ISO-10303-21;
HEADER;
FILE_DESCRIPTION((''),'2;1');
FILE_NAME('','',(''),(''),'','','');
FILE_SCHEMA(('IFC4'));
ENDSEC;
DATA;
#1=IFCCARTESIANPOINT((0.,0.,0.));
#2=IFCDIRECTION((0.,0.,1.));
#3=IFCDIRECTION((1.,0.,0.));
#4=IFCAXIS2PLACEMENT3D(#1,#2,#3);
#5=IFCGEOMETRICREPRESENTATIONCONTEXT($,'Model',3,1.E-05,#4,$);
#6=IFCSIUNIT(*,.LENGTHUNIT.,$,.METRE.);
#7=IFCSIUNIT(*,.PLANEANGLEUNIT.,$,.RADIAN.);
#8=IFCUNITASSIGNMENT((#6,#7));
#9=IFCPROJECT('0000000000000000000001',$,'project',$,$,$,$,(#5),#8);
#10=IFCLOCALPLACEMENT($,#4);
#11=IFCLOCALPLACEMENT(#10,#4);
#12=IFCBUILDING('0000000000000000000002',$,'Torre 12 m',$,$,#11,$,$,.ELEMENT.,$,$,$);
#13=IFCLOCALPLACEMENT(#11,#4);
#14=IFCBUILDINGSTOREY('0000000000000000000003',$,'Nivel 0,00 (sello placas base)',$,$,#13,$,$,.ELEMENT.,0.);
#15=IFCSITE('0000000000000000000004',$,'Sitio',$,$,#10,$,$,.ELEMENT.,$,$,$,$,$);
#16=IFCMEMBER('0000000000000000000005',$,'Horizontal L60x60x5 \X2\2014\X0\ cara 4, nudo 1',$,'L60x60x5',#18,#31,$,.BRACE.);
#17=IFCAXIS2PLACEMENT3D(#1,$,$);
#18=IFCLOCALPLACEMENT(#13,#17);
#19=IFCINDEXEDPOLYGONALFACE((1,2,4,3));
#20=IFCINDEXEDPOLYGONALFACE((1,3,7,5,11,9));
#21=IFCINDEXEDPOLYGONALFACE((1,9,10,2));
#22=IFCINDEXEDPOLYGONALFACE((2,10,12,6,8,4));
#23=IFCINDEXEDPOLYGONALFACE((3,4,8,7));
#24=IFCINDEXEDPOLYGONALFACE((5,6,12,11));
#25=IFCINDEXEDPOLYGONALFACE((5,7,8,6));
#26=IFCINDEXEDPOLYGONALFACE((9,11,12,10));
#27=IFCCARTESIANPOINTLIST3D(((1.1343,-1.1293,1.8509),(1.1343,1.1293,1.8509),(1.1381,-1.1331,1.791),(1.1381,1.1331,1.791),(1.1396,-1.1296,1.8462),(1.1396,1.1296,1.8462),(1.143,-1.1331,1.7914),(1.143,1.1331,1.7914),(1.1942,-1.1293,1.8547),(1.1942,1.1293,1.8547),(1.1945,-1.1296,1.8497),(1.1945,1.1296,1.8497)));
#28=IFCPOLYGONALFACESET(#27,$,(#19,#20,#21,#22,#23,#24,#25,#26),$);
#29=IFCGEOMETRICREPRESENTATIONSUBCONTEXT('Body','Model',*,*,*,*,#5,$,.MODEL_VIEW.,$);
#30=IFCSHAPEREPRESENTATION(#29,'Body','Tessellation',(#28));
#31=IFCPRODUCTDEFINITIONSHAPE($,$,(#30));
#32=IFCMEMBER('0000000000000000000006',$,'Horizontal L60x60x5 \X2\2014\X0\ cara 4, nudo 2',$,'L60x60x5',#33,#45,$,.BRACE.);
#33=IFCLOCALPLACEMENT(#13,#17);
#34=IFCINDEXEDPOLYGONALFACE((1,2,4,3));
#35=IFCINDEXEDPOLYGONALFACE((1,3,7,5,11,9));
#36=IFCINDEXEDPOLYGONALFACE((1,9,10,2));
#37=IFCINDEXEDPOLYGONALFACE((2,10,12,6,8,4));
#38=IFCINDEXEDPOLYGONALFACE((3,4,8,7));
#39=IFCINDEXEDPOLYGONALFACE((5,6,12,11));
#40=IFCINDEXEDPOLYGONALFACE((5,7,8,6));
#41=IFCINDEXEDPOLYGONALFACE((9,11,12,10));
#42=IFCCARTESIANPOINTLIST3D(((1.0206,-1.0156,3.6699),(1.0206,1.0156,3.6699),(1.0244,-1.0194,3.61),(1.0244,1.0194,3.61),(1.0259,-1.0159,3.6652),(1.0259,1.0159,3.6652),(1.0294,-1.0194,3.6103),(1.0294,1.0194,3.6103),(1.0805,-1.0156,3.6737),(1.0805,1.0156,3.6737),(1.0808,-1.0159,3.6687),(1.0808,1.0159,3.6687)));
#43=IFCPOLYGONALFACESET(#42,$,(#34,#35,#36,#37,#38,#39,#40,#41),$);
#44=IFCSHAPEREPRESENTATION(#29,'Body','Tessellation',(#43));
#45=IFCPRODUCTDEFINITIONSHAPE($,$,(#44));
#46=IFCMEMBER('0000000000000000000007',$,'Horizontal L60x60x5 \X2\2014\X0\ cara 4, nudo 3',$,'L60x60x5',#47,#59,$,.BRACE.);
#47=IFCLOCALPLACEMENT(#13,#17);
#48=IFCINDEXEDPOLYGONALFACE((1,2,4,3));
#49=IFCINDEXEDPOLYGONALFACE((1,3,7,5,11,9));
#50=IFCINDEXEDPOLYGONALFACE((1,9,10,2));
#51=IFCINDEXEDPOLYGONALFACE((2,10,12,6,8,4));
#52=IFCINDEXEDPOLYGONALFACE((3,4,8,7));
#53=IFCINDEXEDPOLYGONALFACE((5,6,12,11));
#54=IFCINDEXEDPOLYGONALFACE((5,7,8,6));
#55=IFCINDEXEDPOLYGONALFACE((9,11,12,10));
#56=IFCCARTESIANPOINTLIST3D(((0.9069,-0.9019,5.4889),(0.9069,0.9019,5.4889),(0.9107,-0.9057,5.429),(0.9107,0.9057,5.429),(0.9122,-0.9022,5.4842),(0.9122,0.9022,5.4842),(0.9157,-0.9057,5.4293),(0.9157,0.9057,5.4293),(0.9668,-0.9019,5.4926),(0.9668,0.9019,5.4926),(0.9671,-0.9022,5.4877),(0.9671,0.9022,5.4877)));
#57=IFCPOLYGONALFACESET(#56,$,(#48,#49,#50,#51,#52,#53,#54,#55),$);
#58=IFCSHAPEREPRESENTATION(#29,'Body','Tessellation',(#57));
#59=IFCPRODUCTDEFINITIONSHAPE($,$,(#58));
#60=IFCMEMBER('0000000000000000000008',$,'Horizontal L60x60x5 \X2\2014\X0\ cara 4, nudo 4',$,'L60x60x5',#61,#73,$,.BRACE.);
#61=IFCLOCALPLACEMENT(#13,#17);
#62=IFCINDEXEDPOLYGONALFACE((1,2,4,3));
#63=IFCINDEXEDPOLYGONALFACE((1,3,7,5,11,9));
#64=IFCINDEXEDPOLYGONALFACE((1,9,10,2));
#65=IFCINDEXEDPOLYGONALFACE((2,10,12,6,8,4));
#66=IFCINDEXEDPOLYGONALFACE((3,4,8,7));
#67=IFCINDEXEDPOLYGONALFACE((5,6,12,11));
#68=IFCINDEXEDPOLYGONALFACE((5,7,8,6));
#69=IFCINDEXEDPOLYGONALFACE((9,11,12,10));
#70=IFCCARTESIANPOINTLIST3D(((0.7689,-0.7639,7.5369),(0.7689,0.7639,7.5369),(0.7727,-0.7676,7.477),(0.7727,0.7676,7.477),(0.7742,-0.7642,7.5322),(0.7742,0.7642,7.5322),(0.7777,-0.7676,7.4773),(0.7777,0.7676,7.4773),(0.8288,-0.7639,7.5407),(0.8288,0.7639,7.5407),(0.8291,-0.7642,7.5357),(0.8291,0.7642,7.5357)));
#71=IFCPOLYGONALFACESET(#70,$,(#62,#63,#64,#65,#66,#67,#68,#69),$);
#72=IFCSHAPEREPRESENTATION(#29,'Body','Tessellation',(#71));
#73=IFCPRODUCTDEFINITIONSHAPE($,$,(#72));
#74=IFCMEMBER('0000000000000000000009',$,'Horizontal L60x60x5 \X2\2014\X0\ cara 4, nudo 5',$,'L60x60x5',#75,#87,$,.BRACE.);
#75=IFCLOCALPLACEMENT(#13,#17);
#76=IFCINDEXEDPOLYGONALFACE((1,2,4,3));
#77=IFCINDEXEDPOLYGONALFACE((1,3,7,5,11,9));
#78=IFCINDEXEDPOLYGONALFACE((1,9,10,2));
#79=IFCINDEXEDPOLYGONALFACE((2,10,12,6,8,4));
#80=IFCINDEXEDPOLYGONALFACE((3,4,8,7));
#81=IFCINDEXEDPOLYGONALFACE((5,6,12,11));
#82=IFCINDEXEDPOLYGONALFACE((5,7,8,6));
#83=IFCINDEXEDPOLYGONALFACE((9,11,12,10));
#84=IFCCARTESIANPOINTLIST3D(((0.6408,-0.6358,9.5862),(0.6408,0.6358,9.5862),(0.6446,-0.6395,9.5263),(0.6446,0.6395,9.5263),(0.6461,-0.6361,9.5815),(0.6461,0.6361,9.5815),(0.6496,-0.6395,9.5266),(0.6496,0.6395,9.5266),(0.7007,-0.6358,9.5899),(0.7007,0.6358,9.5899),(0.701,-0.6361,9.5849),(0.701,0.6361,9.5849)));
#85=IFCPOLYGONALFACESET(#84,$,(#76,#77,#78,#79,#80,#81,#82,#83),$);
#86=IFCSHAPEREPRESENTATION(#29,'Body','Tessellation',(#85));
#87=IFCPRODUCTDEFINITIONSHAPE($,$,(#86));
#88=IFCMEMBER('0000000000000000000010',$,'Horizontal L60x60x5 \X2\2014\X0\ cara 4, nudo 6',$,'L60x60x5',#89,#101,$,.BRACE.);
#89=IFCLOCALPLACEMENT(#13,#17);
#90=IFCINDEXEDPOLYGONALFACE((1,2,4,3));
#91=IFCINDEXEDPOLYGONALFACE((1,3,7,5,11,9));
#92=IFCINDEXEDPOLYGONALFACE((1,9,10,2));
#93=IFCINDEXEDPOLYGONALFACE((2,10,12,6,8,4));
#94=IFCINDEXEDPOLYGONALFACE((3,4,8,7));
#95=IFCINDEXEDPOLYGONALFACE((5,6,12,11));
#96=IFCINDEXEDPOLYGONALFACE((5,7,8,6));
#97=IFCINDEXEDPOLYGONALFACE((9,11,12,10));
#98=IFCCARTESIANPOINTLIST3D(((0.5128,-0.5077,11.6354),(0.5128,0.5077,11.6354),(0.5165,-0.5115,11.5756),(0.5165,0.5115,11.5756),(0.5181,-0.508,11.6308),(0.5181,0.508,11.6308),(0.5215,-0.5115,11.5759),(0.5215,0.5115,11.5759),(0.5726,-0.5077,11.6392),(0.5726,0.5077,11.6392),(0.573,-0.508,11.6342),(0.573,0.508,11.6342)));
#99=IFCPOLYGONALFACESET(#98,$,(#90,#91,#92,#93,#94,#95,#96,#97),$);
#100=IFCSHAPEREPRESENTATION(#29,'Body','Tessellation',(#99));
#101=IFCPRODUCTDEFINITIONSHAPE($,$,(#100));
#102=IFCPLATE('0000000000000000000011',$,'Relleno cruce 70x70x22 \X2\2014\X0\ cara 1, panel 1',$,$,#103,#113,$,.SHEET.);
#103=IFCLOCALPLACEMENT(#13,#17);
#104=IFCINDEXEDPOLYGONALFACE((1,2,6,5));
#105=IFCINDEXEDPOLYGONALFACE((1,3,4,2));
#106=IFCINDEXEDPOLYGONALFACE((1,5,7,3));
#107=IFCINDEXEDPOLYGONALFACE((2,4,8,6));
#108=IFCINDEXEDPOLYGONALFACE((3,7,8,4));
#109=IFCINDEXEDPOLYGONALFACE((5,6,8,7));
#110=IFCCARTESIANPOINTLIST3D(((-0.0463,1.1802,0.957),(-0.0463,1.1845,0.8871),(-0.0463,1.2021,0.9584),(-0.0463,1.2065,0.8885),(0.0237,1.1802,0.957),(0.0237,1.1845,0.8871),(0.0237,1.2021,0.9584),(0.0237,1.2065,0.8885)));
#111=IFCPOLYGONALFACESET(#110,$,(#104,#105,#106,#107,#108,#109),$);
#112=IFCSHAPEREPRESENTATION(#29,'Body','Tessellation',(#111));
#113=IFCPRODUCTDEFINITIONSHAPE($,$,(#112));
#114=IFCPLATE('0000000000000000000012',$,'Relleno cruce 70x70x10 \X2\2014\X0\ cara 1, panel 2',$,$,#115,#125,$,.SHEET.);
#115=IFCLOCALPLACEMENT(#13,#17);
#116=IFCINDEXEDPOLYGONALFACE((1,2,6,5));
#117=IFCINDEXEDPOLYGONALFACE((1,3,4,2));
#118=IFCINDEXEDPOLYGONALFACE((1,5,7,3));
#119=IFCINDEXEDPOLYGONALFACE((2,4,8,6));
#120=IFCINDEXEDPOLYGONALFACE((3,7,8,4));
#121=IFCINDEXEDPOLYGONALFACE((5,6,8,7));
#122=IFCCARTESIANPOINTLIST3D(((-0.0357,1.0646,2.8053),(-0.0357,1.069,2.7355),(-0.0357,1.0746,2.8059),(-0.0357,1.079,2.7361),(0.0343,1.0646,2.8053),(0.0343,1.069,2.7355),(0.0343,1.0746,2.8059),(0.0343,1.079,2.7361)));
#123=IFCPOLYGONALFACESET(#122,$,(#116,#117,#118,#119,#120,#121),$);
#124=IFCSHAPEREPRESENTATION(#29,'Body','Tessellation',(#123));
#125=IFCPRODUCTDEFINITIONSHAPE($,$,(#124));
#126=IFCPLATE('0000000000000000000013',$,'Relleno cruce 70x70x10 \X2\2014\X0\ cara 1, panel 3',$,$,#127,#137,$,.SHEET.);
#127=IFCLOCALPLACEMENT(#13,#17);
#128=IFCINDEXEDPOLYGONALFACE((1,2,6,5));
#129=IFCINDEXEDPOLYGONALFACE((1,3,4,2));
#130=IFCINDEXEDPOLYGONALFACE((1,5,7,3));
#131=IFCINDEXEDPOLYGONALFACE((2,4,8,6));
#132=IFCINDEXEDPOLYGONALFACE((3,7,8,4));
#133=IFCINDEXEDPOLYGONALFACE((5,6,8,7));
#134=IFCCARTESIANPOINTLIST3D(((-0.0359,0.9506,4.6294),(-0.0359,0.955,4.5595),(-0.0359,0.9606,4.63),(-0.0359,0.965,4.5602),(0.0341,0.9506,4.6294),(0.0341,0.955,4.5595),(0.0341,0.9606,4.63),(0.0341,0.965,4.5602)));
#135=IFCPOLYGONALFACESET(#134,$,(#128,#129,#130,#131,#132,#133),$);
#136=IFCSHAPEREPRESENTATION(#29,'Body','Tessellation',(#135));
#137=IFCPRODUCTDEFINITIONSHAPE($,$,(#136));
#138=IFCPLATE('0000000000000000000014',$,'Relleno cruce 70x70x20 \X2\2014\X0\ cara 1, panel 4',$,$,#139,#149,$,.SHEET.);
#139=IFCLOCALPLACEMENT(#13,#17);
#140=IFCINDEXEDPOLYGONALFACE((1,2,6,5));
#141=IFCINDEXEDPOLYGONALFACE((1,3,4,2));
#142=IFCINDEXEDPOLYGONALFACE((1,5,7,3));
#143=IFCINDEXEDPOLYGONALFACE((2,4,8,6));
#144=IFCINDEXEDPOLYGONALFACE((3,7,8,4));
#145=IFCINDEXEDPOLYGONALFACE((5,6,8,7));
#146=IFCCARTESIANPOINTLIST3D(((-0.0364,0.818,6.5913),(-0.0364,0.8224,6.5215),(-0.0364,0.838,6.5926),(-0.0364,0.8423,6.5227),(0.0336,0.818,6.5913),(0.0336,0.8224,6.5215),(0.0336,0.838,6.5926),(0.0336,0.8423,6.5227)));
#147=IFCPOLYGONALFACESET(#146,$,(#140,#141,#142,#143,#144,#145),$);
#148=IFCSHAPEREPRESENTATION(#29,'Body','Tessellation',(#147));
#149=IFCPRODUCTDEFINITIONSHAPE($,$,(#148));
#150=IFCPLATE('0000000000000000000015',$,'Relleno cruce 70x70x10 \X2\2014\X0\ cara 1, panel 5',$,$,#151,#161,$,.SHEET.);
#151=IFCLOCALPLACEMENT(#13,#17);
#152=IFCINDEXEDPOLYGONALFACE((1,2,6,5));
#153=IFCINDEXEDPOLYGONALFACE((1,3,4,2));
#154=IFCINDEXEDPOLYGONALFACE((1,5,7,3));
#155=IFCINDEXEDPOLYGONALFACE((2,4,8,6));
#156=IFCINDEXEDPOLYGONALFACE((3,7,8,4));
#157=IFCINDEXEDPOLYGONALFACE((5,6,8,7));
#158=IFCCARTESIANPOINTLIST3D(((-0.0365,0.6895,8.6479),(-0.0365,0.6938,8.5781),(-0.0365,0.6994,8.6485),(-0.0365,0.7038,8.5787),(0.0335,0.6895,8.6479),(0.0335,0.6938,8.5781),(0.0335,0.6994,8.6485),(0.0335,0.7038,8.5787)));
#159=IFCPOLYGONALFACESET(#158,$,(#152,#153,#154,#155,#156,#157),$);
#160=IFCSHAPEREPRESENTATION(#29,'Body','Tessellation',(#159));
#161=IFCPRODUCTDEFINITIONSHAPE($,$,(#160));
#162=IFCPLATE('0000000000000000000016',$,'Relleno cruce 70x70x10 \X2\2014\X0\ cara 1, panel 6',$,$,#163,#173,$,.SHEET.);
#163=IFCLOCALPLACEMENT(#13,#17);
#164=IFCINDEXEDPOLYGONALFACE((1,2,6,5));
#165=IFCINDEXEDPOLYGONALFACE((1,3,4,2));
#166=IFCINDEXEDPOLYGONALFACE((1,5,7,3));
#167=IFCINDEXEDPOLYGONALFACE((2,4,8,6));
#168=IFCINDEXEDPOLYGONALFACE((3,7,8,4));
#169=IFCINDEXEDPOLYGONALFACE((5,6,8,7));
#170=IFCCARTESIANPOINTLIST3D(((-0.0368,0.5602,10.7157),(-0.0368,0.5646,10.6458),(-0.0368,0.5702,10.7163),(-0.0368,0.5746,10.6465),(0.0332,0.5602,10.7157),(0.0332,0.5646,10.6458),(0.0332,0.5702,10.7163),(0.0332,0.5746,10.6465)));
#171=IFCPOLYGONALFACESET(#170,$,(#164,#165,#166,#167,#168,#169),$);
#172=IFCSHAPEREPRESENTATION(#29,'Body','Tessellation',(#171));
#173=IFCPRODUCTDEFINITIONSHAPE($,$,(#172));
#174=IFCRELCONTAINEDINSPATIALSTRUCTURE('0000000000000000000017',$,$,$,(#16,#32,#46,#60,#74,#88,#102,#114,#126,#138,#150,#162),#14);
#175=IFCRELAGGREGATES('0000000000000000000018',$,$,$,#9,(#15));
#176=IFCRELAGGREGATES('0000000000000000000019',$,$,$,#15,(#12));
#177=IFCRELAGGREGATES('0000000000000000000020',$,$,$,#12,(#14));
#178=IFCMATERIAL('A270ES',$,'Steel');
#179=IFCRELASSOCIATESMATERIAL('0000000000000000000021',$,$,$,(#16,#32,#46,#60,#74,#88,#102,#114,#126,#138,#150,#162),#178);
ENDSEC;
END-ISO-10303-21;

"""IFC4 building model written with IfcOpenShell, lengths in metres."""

from ifc_helpers import new_model, si_unit, frame, origin_with_axes, place, context, subcontext, project, spatial, polyline, outline, extrude, clip, halfspace, material, element, save


model = new_model("IFC4")

# Units and contexts
model_context = context("Model", 3, precision=1e-05, world=origin_with_axes())
body_context = subcontext(model_context, "Body", "Model", "MODEL_VIEW")
ifc_project = project(units=[si_unit("LENGTHUNIT", "METRE"), si_unit("PLANEANGLEUNIT", "RADIAN")], contexts=[model_context])

# Site, building, storey
site_placement = place(None, origin_with_axes())
site = spatial("IfcSite", under=ifc_project, at=site_placement, Name="Sitio", CompositionType="ELEMENT")
building_placement = place(site_placement, origin_with_axes())
building = spatial("IfcBuilding", under=site, at=building_placement, Name="Torre 12 m", CompositionType="ELEMENT")
storey_placement = place(building_placement, origin_with_axes())
storey = spatial("IfcBuildingStorey", under=building, at=storey_placement, Name="Nivel 0,00 (sello placas base)", CompositionType="ELEMENT", Elevation=0.0)

# Members
ifc_material_1 = material(Name="A270ES", Category="Steel")
placement = place(storey_placement, origin_with_axes())
element("IfcMember", 1, at=placement, inside=storey, material=ifc_material_1, Name="Horizontal L60x60x5 — cara 4, nudo 1", ObjectType="L60x60x5", PredefinedType="BRACE", context=body_context, shape_type="Clipping", body=[
    clip(clip(extrude(outline(polyline([(0.0, -0.06), (0.005, -0.06), (0.005, -0.005), (0.06, -0.005), (0.06, 0.0), (0.0, 0.0), (0.0, -0.06)])), frame((1.1343, -1.1913, 1.8509), z_axis=(0.0, 1.0, 0.0), x_axis=(0.062378, 0.0, -0.998053)), (0.0, 0.0, 1.0), 2.3826), halfspace(frame((1.1363, -1.1313, 1.8187), z_axis=(0.003884, 0.99806, -0.062136), x_axis=(0.941016, -0.024671, -0.337462)), True)), halfspace(frame((1.1363, 1.1313, 1.8187), z_axis=(0.003884, -0.99806, -0.062136), x_axis=(-0.930474, -0.02637, 0.365409)), True)),
])
element("IfcMember", 2, at=placement, inside=storey, material=ifc_material_1, Name="Horizontal L60x60x5 — cara 4, nudo 2", ObjectType="L60x60x5", PredefinedType="BRACE", context=body_context, shape_type="Clipping", body=[
    clip(clip(extrude(outline(polyline([(0.0, -0.06), (0.005, -0.06), (0.005, -0.005), (0.06, -0.005), (0.06, 0.0), (0.0, 0.0), (0.0, -0.06)])), frame((1.0206, -1.0776, 3.6699), z_axis=(0.0, 1.0, 0.0), x_axis=(0.062378, 0.0, -0.998053)), (0.0, 0.0, 1.0), 2.1552), halfspace(frame((1.0226, -1.0176, 3.6377), z_axis=(0.003884, 0.99806, -0.062136), x_axis=(0.941016, -0.024671, -0.337462)), True)), halfspace(frame((1.0226, 1.0176, 3.6377), z_axis=(0.003884, -0.99806, -0.062136), x_axis=(-0.930474, -0.02637, 0.365409)), True)),
])
element("IfcMember", 3, at=placement, inside=storey, material=ifc_material_1, Name="Horizontal L60x60x5 — cara 4, nudo 3", ObjectType="L60x60x5", PredefinedType="BRACE", context=body_context, shape_type="Clipping", body=[
    clip(clip(extrude(outline(polyline([(0.0, -0.06), (0.005, -0.06), (0.005, -0.005), (0.06, -0.005), (0.06, 0.0), (0.0, 0.0), (0.0, -0.06)])), frame((0.9069, -0.9639, 5.4889), z_axis=(0.0, 1.0, 0.0), x_axis=(0.062378, 0.0, -0.998053)), (0.0, 0.0, 1.0), 1.9279), halfspace(frame((0.909, -0.904, 5.4566), z_axis=(0.003884, 0.99806, -0.062136), x_axis=(0.941016, -0.024671, -0.337462)), True)), halfspace(frame((0.909, 0.904, 5.4566), z_axis=(0.003884, -0.99806, -0.062136), x_axis=(-0.930474, -0.02637, 0.365409)), True)),
])
element("IfcMember", 4, at=placement, inside=storey, material=ifc_material_1, Name="Horizontal L60x60x5 — cara 4, nudo 4", ObjectType="L60x60x5", PredefinedType="BRACE", context=body_context, shape_type="Clipping", body=[
    clip(clip(extrude(outline(polyline([(0.0, -0.06), (0.005, -0.06), (0.005, -0.005), (0.06, -0.005), (0.06, 0.0), (0.0, 0.0), (0.0, -0.06)])), frame((0.7689, -0.8259, 7.5369), z_axis=(0.0, 1.0, 0.0), x_axis=(0.062378, 0.0, -0.998053)), (0.0, 0.0, 1.0), 1.6517), halfspace(frame((0.7709, -0.7659, 7.5047), z_axis=(0.003884, 0.99806, -0.062136), x_axis=(0.941016, -0.024671, -0.337462)), True)), halfspace(frame((0.7709, 0.7659, 7.5047), z_axis=(0.003884, -0.99806, -0.062136), x_axis=(-0.930474, -0.02637, 0.365409)), True)),
])
element("IfcMember", 5, at=placement, inside=storey, material=ifc_material_1, Name="Horizontal L60x60x5 — cara 4, nudo 5", ObjectType="L60x60x5", PredefinedType="BRACE", context=body_context, shape_type="Clipping", body=[
    clip(clip(extrude(outline(polyline([(0.0, -0.06), (0.005, -0.06), (0.005, -0.005), (0.06, -0.005), (0.06, 0.0), (0.0, 0.0), (0.0, -0.06)])), frame((0.6408, -0.6978, 9.5862), z_axis=(0.0, 1.0, 0.0), x_axis=(0.062378, 0.0, -0.998053)), (0.0, 0.0, 1.0), 1.3956), halfspace(frame((0.6429, -0.6378, 9.5539), z_axis=(0.003884, 0.99806, -0.062136), x_axis=(0.941016, -0.024671, -0.337462)), True)), halfspace(frame((0.6429, 0.6378, 9.5539), z_axis=(0.003884, -0.99806, -0.062136), x_axis=(-0.930474, -0.02637, 0.365409)), True)),
])
element("IfcMember", 6, at=placement, inside=storey, material=ifc_material_1, Name="Horizontal L60x60x5 — cara 4, nudo 6", ObjectType="L60x60x5", PredefinedType="BRACE", context=body_context, shape_type="Clipping", body=[
    clip(clip(extrude(outline(polyline([(0.0, -0.06), (0.005, -0.06), (0.005, -0.005), (0.06, -0.005), (0.06, 0.0), (0.0, 0.0), (0.0, -0.06)])), frame((0.5128, -0.5697, 11.6355), z_axis=(0.0, 1.0, 0.0), x_axis=(0.062378, 0.0, -0.998053)), (0.0, 0.0, 1.0), 1.1394), halfspace(frame((0.5148, -0.5097, 11.6032), z_axis=(0.003884, 0.99806, -0.062136), x_axis=(0.941016, -0.024671, -0.337462)), True)), halfspace(frame((0.5148, 0.5097, 11.6032), z_axis=(0.003884, -0.99806, -0.062136), x_axis=(-0.930474, -0.02637, 0.365409)), True)),
])

# Plates
element("IfcPlate", 7, at=placement, inside=storey, material=ifc_material_1, Name="Relleno cruce 70x70x22 — cara 1, panel 1", PredefinedType="SHEET", context=body_context, shape_type="SweptSolid", body=[
    extrude(outline(polyline([(-0.035, -0.035), (0.035, -0.035), (0.035, 0.035), (-0.035, 0.035), (-0.035, -0.035)])), frame((-0.0113, 1.2043, 0.9234), z_axis=(0.0, -0.998053, -0.062378), x_axis=(-1.0, 0.0, 0.0)), (0.0, 0.0, 1.0), 0.022),
])
element("IfcPlate", 8, at=placement, inside=storey, material=ifc_material_1, Name="Relleno cruce 70x70x10 — cara 1, panel 2", PredefinedType="SHEET", context=body_context, shape_type="SweptSolid", body=[
    extrude(outline(polyline([(-0.035, -0.035), (0.035, -0.035), (0.035, 0.035), (-0.035, 0.035), (-0.035, -0.035)])), frame((-0.0007, 1.0768, 2.771), z_axis=(0.0, -0.998053, -0.062378), x_axis=(-1.0, 0.0, 0.0)), (0.0, 0.0, 1.0), 0.01),
])
element("IfcPlate", 9, at=placement, inside=storey, material=ifc_material_1, Name="Relleno cruce 70x70x10 — cara 1, panel 3", PredefinedType="SHEET", context=body_context, shape_type="SweptSolid", body=[
    extrude(outline(polyline([(-0.035, -0.035), (0.035, -0.035), (0.035, 0.035), (-0.035, 0.035), (-0.035, -0.035)])), frame((-0.0009, 0.9628, 4.5951), z_axis=(0.0, -0.998053, -0.062378), x_axis=(-1.0, 0.0, 0.0)), (0.0, 0.0, 1.0), 0.01),
])
element("IfcPlate", 10, at=placement, inside=storey, material=ifc_material_1, Name="Relleno cruce 70x70x20 — cara 1, panel 4", PredefinedType="SHEET", context=body_context, shape_type="SweptSolid", body=[
    extrude(outline(polyline([(-0.035, -0.035), (0.035, -0.035), (0.035, 0.035), (-0.035, 0.035), (-0.035, -0.035)])), frame((-0.0014, 0.8401, 6.5577), z_axis=(0.0, -0.998053, -0.062378), x_axis=(-1.0, 0.0, 0.0)), (0.0, 0.0, 1.0), 0.02),
])
element("IfcPlate", 11, at=placement, inside=storey, material=ifc_material_1, Name="Relleno cruce 70x70x10 — cara 1, panel 5", PredefinedType="SHEET", context=body_context, shape_type="SweptSolid", body=[
    extrude(outline(polyline([(-0.035, -0.035), (0.035, -0.035), (0.035, 0.035), (-0.035, 0.035), (-0.035, -0.035)])), frame((-0.0015, 0.7016, 8.6136), z_axis=(0.0, -0.998053, -0.062378), x_axis=(-1.0, 0.0, 0.0)), (0.0, 0.0, 1.0), 0.01),
])
element("IfcPlate", 12, at=placement, inside=storey, material=ifc_material_1, Name="Relleno cruce 70x70x10 — cara 1, panel 6", PredefinedType="SHEET", context=body_context, shape_type="SweptSolid", body=[
    extrude(outline(polyline([(-0.035, -0.035), (0.035, -0.035), (0.035, 0.035), (-0.035, 0.035), (-0.035, -0.035)])), frame((-0.0018, 0.5724, 10.6814), z_axis=(0.0, -0.998053, -0.062378), x_axis=(-1.0, 0.0, 0.0)), (0.0, 0.0, 1.0), 0.01),
])

save(model, "model.ifc")
